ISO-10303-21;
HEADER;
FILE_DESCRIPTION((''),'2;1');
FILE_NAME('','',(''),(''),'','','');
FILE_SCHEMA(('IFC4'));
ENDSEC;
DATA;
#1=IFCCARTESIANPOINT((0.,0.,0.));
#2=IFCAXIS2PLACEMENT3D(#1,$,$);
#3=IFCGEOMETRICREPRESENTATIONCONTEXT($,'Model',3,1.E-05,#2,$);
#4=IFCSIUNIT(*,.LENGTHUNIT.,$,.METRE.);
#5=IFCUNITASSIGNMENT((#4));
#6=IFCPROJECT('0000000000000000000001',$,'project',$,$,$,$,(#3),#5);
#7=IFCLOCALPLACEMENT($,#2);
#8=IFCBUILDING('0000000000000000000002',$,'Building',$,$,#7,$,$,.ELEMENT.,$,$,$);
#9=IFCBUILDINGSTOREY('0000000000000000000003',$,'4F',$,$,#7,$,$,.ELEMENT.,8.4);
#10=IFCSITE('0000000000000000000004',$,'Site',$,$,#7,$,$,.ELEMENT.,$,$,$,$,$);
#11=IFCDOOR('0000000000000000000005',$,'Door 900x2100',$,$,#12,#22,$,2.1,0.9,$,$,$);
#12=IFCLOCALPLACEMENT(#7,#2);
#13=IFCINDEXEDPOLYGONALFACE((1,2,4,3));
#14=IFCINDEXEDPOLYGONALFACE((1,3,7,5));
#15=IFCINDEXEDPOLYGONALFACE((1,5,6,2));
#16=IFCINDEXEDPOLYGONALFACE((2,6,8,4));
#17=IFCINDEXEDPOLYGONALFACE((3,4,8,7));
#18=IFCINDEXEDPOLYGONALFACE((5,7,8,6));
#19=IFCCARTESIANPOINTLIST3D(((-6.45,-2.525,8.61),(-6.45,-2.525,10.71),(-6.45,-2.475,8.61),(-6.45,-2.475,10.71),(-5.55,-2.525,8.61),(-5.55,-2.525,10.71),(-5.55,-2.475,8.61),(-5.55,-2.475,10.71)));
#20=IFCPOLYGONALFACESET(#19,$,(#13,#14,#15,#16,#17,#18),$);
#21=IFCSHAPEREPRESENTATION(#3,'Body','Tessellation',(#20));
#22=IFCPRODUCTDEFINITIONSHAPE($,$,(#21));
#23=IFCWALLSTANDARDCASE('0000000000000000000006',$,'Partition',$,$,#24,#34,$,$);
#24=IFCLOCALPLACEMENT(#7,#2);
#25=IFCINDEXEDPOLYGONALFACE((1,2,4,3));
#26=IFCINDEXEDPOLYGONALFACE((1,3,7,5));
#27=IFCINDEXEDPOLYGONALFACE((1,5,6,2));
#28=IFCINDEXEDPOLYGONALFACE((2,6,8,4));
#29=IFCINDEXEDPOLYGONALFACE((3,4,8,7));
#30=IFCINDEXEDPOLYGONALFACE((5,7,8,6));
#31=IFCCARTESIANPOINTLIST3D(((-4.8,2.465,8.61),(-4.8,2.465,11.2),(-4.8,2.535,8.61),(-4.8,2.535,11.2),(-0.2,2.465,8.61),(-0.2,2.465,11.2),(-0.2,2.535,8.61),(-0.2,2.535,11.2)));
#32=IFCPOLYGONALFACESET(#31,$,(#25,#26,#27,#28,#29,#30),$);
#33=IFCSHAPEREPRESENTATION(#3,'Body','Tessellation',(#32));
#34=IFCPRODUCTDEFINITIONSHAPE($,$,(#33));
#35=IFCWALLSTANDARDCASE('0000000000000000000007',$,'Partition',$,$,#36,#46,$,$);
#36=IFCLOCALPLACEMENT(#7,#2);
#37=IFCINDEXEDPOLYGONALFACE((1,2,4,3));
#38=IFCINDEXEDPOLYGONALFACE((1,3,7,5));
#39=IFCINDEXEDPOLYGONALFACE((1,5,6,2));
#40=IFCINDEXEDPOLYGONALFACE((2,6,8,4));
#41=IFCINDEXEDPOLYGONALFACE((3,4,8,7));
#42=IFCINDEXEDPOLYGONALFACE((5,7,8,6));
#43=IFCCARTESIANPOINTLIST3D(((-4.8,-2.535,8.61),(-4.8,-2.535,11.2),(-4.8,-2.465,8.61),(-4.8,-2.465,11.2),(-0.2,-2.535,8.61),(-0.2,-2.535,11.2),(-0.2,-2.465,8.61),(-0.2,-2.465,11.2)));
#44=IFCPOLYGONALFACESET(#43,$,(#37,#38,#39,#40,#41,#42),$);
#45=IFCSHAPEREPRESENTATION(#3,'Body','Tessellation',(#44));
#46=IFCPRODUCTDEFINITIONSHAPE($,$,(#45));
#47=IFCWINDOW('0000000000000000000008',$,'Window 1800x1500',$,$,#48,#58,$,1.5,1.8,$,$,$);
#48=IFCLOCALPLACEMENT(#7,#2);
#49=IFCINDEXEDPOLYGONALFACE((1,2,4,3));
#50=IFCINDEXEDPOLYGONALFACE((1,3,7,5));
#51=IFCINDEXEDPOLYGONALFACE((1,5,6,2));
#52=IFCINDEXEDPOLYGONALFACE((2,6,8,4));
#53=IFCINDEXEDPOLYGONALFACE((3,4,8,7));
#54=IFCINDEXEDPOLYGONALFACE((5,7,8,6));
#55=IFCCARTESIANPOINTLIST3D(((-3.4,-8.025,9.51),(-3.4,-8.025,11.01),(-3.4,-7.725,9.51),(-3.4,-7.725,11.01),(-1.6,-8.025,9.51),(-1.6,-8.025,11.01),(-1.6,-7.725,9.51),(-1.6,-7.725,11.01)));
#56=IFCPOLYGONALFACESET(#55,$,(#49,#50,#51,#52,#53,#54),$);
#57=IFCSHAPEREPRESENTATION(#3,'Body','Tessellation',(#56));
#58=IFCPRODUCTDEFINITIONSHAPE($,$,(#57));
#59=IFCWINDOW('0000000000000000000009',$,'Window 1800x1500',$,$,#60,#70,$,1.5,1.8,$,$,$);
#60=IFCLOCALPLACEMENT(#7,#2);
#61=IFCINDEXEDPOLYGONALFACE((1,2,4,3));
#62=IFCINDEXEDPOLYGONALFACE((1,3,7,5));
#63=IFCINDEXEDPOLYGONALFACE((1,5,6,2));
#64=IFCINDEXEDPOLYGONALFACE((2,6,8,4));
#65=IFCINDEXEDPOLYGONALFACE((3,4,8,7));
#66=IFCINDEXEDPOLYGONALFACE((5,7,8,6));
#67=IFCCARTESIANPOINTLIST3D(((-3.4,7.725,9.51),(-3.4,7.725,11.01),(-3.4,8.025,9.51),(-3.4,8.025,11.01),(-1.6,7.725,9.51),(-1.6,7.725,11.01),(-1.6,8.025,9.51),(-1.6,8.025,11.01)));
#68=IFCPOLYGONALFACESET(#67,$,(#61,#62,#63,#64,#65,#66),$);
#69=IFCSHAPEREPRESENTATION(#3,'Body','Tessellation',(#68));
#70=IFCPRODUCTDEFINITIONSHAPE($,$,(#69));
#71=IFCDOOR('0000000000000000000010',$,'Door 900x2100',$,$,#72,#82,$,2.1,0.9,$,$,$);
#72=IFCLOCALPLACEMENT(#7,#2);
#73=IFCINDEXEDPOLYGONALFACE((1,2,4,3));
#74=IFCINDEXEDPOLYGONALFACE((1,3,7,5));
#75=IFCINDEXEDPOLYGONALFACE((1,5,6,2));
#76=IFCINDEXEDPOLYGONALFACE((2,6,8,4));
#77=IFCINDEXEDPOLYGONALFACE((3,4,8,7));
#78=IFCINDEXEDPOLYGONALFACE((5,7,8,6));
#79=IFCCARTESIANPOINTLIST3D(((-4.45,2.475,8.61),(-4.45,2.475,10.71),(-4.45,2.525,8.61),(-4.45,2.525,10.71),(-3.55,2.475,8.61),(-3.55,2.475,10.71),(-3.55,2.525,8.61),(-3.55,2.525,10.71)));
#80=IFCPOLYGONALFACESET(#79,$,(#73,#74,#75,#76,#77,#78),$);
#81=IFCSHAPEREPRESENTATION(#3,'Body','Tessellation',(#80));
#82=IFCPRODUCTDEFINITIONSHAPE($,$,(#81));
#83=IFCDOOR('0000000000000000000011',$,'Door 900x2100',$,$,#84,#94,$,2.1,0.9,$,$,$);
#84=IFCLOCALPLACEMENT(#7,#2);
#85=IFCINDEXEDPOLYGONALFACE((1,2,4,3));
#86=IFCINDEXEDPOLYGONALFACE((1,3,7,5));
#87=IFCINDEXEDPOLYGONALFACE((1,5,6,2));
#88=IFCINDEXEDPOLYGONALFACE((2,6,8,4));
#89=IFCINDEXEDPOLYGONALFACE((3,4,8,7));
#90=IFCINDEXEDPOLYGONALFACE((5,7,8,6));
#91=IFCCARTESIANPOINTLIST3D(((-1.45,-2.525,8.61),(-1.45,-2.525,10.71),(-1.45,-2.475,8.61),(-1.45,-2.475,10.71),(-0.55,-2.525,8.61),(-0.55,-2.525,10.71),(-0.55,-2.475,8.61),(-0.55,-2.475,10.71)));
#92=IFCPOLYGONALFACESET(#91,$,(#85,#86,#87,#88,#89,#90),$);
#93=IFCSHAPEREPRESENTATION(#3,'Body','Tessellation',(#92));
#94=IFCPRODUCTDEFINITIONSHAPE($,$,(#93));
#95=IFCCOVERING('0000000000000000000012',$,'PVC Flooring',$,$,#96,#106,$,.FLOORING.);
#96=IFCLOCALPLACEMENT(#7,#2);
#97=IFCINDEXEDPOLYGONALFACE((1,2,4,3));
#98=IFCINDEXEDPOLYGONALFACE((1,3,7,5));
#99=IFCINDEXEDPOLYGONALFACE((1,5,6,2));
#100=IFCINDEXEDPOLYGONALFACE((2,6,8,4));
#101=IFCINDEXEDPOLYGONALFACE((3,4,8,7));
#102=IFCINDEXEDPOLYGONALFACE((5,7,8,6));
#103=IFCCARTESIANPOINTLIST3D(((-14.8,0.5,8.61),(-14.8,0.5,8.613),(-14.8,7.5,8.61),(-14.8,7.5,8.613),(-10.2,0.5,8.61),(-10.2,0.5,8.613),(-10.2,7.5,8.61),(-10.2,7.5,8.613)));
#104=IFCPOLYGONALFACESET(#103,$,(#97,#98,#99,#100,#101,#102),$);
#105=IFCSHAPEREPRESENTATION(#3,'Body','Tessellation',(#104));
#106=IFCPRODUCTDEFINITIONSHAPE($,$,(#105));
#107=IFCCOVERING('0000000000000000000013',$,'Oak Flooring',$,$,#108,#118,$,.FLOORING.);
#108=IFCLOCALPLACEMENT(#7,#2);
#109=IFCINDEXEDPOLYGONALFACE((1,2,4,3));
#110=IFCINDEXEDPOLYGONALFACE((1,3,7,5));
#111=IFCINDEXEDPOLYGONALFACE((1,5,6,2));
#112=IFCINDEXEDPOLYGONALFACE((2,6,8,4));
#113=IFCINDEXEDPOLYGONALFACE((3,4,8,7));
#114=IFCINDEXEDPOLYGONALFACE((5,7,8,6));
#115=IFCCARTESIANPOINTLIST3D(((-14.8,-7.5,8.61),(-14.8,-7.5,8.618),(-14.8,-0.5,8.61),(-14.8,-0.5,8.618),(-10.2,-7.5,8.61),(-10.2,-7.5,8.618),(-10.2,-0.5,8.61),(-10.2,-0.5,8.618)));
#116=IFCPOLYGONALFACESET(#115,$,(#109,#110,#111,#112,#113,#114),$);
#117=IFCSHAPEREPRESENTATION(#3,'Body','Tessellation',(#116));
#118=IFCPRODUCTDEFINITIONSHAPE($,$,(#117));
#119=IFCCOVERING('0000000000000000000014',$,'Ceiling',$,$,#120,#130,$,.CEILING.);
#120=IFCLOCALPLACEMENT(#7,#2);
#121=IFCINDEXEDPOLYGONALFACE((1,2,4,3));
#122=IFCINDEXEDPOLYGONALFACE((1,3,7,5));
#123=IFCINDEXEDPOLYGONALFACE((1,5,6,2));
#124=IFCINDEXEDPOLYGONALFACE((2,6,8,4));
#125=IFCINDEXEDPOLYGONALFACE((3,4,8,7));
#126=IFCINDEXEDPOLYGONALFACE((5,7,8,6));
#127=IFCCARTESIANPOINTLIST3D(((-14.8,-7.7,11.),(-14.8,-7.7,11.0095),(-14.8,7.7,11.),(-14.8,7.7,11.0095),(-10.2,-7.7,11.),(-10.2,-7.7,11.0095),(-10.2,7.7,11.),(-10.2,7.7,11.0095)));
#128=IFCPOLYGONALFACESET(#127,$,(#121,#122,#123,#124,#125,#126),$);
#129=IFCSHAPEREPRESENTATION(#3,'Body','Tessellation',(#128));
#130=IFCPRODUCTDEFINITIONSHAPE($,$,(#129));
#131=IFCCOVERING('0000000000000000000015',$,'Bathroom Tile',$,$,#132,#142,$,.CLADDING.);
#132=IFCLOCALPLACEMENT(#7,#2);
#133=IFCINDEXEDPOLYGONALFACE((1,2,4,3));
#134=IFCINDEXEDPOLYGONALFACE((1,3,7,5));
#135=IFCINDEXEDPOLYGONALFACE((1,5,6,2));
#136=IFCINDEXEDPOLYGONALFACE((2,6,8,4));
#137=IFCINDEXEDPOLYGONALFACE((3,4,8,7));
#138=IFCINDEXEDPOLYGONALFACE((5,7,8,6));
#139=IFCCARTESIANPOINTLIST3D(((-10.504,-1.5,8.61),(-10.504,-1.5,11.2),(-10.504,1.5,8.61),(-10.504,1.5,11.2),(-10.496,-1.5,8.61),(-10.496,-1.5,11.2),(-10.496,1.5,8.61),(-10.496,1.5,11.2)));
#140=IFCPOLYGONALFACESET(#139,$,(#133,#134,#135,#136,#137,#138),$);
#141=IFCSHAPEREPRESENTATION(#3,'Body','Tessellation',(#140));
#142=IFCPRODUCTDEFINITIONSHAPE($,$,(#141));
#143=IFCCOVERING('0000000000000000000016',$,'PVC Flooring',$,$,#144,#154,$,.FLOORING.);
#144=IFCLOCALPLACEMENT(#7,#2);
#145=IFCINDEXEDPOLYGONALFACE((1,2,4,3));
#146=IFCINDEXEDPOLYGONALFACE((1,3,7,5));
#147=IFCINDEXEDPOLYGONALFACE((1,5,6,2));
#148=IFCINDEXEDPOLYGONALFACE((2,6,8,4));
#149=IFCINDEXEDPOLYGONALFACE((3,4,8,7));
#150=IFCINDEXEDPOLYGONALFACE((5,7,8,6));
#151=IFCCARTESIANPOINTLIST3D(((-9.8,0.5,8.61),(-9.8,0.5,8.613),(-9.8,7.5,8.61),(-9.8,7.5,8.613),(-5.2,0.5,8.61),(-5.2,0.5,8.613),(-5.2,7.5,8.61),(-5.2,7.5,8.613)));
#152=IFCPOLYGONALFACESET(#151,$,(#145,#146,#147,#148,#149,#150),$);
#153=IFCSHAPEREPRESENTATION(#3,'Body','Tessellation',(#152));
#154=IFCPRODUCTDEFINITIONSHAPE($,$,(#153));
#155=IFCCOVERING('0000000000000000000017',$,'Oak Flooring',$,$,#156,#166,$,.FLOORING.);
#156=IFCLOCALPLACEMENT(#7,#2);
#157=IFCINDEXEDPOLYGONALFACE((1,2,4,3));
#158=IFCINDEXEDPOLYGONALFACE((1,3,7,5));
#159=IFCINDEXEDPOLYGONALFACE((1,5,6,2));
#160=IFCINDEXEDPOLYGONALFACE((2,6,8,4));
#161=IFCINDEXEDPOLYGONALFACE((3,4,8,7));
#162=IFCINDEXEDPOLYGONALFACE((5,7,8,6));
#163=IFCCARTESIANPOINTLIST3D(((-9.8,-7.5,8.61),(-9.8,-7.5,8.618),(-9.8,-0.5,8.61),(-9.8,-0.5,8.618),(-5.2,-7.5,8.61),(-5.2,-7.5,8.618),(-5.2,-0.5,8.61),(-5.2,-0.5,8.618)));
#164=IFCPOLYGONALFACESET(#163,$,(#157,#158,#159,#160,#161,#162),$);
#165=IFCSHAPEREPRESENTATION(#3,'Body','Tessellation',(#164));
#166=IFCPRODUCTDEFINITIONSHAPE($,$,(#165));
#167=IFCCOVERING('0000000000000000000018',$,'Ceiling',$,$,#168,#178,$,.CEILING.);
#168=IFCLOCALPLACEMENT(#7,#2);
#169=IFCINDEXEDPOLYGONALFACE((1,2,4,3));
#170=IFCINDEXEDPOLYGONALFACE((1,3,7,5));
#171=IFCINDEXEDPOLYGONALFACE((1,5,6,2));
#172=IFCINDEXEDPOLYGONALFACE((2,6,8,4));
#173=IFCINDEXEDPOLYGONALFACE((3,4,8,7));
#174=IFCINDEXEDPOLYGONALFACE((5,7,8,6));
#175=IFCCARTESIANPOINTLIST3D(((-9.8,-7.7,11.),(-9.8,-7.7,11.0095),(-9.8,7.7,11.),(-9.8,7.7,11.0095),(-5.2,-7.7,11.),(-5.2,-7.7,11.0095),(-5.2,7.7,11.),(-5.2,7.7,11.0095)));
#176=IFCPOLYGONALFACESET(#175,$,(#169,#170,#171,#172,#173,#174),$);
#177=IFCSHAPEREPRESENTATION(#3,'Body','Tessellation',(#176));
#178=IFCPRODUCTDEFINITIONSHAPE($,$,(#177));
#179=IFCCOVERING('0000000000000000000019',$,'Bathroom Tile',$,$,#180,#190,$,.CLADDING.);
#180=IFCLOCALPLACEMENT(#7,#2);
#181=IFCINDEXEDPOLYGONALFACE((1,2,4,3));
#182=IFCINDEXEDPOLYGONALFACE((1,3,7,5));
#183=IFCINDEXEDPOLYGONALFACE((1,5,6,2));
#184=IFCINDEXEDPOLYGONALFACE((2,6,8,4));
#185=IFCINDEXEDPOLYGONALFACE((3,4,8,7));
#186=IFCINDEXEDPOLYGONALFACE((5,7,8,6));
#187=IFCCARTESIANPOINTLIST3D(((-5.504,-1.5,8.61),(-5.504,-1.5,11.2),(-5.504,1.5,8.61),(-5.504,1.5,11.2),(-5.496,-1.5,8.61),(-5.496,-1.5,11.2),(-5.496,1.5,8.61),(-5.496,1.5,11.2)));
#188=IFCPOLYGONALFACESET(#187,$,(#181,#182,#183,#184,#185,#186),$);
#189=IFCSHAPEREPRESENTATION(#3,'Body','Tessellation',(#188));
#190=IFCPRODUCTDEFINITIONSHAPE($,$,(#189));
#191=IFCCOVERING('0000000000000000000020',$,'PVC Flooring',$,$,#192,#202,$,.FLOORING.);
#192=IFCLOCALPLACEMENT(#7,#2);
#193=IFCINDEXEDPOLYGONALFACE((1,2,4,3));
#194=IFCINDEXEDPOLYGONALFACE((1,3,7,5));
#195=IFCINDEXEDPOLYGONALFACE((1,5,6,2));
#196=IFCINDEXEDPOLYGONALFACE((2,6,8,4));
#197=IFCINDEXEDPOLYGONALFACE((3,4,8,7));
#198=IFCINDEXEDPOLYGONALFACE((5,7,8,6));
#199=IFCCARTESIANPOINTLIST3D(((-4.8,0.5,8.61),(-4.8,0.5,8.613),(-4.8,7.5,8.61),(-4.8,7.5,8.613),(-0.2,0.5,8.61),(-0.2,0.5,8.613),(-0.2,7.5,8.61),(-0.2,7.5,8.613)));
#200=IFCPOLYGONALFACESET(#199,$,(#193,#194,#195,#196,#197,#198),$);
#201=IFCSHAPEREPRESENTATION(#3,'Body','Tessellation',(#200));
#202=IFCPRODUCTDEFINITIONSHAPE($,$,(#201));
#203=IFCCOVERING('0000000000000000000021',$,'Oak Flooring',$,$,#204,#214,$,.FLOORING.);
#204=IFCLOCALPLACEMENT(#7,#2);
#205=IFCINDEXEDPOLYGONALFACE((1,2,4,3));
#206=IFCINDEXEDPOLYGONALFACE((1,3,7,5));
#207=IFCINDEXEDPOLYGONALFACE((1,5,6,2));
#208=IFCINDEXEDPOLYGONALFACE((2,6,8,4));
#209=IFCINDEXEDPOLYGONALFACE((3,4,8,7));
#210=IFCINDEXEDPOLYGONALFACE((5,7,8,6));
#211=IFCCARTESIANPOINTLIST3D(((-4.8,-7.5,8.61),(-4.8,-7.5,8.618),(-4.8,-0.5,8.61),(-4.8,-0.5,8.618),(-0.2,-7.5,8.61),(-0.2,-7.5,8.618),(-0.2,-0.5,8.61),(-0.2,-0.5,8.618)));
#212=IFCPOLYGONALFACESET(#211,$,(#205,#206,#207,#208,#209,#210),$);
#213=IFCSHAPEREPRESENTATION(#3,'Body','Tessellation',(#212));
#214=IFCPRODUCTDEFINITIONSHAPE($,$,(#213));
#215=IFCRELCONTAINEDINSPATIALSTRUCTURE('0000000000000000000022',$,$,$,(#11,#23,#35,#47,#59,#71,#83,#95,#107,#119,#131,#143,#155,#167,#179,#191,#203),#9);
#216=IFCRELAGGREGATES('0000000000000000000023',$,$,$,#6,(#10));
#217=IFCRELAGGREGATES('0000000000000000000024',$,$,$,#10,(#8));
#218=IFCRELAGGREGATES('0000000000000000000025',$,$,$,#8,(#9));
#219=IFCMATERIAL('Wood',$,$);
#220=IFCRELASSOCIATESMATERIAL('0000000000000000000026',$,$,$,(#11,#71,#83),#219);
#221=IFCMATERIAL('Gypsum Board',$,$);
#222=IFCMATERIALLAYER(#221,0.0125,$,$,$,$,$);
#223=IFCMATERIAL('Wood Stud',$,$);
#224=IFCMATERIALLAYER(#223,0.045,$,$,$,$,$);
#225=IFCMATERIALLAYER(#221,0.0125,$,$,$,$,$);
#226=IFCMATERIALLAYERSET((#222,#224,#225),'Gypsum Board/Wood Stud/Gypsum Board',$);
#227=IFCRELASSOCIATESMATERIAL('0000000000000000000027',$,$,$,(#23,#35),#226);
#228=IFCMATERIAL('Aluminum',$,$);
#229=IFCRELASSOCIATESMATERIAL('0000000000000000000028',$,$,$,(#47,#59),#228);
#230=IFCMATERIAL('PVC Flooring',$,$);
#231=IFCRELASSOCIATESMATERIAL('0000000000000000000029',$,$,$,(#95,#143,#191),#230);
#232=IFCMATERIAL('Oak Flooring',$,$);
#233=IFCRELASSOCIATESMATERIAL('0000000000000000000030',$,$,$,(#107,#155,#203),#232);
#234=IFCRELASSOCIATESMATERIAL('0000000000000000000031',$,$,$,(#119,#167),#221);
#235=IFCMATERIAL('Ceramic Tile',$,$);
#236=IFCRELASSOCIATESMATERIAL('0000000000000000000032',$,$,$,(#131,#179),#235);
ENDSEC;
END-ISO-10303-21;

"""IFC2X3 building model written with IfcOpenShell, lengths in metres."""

from ifc_helpers import new_model, si_unit, frame, origin, origin_2d, place, context, project, spatial, rectangle, extrude, material, layer, layer_set, layer_usage, element, save


model = new_model("IFC2X3")

# Units and contexts
model_context = context("Model", 3, precision=1e-05, world=origin())
ifc_project = project(units=[si_unit("LENGTHUNIT", "METRE")], contexts=[model_context])

# Site, building, storey
placement = place(None, origin())
site = spatial("IfcSite", under=ifc_project, at=placement, Name="Site", CompositionType="ELEMENT")
building = spatial("IfcBuilding", under=site, at=placement, Name="Building", CompositionType="ELEMENT")
storey = spatial("IfcBuildingStorey", under=building, at=placement, Name="4F", CompositionType="ELEMENT", Elevation=8.4)

# Shared definitions
ifc_material_1 = material(Name="Gypsum Board")
ifc_layer_1 = layer(ifc_material_1, 0.0125)
ifc_material_2 = material(Name="Wood Stud")
ifc_layer_2 = layer(ifc_material_2, 0.045)
ifc_layer_3 = layer(ifc_material_1, 0.0125)
ifc_layer_set_1 = layer_set([ifc_layer_1, ifc_layer_2, ifc_layer_3], Name="Gypsum Board/Wood Stud/Gypsum Board")
ifc_layer_usage_1 = layer_usage(ifc_layer_set_1, "AXIS2", "POSITIVE", 0.0)

# Shared definitions
ifc_material_3 = material(Name="Aluminum")

# Shared definitions
ifc_material_4 = material(Name="Wood")

# Door
for number, where, name in (
    (1, (-6.0, -2.5, 8.61), "Door 900x2100"),
):
    element("IfcDoor", number, at=place(None, frame(where)), inside=storey, material=ifc_material_4, Name=name, OverallHeight=2.1, OverallWidth=0.9, context=model_context, shape_type="SweptSolid", body=[
        extrude(rectangle(XDim=0.9, YDim=0.05, at=origin_2d()), origin(), (0.0, 0.0, 1.0), 2.1),
    ])

# Walls
for number, where, name in (
    (2, (-2.5, 2.5, 8.61), "Partition"),
    (3, (-2.5, -2.5, 8.61), "Partition"),
):
    element("IfcWallStandardCase", number, at=place(None, frame(where)), inside=storey, material=ifc_layer_usage_1, Name=name, context=model_context, shape_type="SweptSolid", body=[
        extrude(rectangle(XDim=4.6, YDim=0.07, at=origin_2d()), origin(), (0.0, 0.0, 1.0), 2.59),
    ])

# Windows
for number, where, name in (
    (4, (-2.5, -7.875, 9.51), "Window 1800x1500"),
    (5, (-2.5, 7.875, 9.51), "Window 1800x1500"),
):
    element("IfcWindow", number, at=place(None, frame(where)), inside=storey, material=ifc_material_3, Name=name, OverallHeight=1.5, OverallWidth=1.8, context=model_context, shape_type="SweptSolid", body=[
        extrude(rectangle(XDim=1.8, YDim=0.3, at=origin_2d()), origin(), (0.0, 0.0, 1.0), 1.5),
    ])

# Doors
for number, where, name in (
    (6, (-4.0, 2.5, 8.61), "Door 900x2100"),
    (7, (-1.0, -2.5, 8.61), "Door 900x2100"),
):
    element("IfcDoor", number, at=place(None, frame(where)), inside=storey, material=ifc_material_4, Name=name, OverallHeight=2.1, OverallWidth=0.9, context=model_context, shape_type="SweptSolid", body=[
        extrude(rectangle(XDim=0.9, YDim=0.05, at=origin_2d()), origin(), (0.0, 0.0, 1.0), 2.1),
    ])

# Coverings
ifc_material_5 = material(Name="PVC Flooring")
covering_1_placement = place(None, frame((-12.5, 4.0, 8.61)))
element("IfcCovering", 8, at=covering_1_placement, inside=storey, material=ifc_material_5, Name="PVC Flooring", PredefinedType="FLOORING", context=model_context, shape_type="SweptSolid", body=[
    extrude(rectangle(XDim=4.6, YDim=7.0, at=origin_2d()), origin(), (0.0, 0.0, 1.0), 0.003),
])
ifc_material_6 = material(Name="Oak Flooring")
covering_2_placement = place(None, frame((-12.5, -4.0, 8.61)))
element("IfcCovering", 9, at=covering_2_placement, inside=storey, material=ifc_material_6, Name="Oak Flooring", PredefinedType="FLOORING", context=model_context, shape_type="SweptSolid", body=[
    extrude(rectangle(XDim=4.6, YDim=7.0, at=origin_2d()), origin(), (0.0, 0.0, 1.0), 0.008),
])
covering_3_placement = place(None, frame((-12.5, 0.0, 11.0)))
element("IfcCovering", 10, at=covering_3_placement, inside=storey, material=ifc_material_1, Name="Ceiling", PredefinedType="CEILING", context=model_context, shape_type="SweptSolid", body=[
    extrude(rectangle(XDim=4.6, YDim=15.4, at=origin_2d()), origin(), (0.0, 0.0, 1.0), 0.0095),
])
ifc_material_7 = material(Name="Ceramic Tile")
covering_4_placement = place(None, frame((-10.5, 0.0, 8.61)))
element("IfcCovering", 11, at=covering_4_placement, inside=storey, material=ifc_material_7, Name="Bathroom Tile", PredefinedType="CLADDING", context=model_context, shape_type="SweptSolid", body=[
    extrude(rectangle(XDim=0.008, YDim=3.0, at=origin_2d()), origin(), (0.0, 0.0, 1.0), 2.59),
])
covering_5_placement = place(None, frame((-7.5, 4.0, 8.61)))
element("IfcCovering", 12, at=covering_5_placement, inside=storey, material=ifc_material_5, Name="PVC Flooring", PredefinedType="FLOORING", context=model_context, shape_type="SweptSolid", body=[
    extrude(rectangle(XDim=4.6, YDim=7.0, at=origin_2d()), origin(), (0.0, 0.0, 1.0), 0.003),
])
covering_6_placement = place(None, frame((-7.5, -4.0, 8.61)))
element("IfcCovering", 13, at=covering_6_placement, inside=storey, material=ifc_material_6, Name="Oak Flooring", PredefinedType="FLOORING", context=model_context, shape_type="SweptSolid", body=[
    extrude(rectangle(XDim=4.6, YDim=7.0, at=origin_2d()), origin(), (0.0, 0.0, 1.0), 0.008),
])
covering_7_placement = place(None, frame((-7.5, 0.0, 11.0)))
element("IfcCovering", 14, at=covering_7_placement, inside=storey, material=ifc_material_1, Name="Ceiling", PredefinedType="CEILING", context=model_context, shape_type="SweptSolid", body=[
    extrude(rectangle(XDim=4.6, YDim=15.4, at=origin_2d()), origin(), (0.0, 0.0, 1.0), 0.0095),
])
covering_8_placement = place(None, frame((-5.5, 0.0, 8.61)))
element("IfcCovering", 15, at=covering_8_placement, inside=storey, material=ifc_material_7, Name="Bathroom Tile", PredefinedType="CLADDING", context=model_context, shape_type="SweptSolid", body=[
    extrude(rectangle(XDim=0.008, YDim=3.0, at=origin_2d()), origin(), (0.0, 0.0, 1.0), 2.59),
])
covering_9_placement = place(None, frame((-2.5, 4.0, 8.61)))
element("IfcCovering", 16, at=covering_9_placement, inside=storey, material=ifc_material_5, Name="PVC Flooring", PredefinedType="FLOORING", context=model_context, shape_type="SweptSolid", body=[
    extrude(rectangle(XDim=4.6, YDim=7.0, at=origin_2d()), origin(), (0.0, 0.0, 1.0), 0.003),
])
covering_10_placement = place(None, frame((-2.5, -4.0, 8.61)))
element("IfcCovering", 17, at=covering_10_placement, inside=storey, material=ifc_material_6, Name="Oak Flooring", PredefinedType="FLOORING", context=model_context, shape_type="SweptSolid", body=[
    extrude(rectangle(XDim=4.6, YDim=7.0, at=origin_2d()), origin(), (0.0, 0.0, 1.0), 0.008),
])

save(model, "model.ifc")
